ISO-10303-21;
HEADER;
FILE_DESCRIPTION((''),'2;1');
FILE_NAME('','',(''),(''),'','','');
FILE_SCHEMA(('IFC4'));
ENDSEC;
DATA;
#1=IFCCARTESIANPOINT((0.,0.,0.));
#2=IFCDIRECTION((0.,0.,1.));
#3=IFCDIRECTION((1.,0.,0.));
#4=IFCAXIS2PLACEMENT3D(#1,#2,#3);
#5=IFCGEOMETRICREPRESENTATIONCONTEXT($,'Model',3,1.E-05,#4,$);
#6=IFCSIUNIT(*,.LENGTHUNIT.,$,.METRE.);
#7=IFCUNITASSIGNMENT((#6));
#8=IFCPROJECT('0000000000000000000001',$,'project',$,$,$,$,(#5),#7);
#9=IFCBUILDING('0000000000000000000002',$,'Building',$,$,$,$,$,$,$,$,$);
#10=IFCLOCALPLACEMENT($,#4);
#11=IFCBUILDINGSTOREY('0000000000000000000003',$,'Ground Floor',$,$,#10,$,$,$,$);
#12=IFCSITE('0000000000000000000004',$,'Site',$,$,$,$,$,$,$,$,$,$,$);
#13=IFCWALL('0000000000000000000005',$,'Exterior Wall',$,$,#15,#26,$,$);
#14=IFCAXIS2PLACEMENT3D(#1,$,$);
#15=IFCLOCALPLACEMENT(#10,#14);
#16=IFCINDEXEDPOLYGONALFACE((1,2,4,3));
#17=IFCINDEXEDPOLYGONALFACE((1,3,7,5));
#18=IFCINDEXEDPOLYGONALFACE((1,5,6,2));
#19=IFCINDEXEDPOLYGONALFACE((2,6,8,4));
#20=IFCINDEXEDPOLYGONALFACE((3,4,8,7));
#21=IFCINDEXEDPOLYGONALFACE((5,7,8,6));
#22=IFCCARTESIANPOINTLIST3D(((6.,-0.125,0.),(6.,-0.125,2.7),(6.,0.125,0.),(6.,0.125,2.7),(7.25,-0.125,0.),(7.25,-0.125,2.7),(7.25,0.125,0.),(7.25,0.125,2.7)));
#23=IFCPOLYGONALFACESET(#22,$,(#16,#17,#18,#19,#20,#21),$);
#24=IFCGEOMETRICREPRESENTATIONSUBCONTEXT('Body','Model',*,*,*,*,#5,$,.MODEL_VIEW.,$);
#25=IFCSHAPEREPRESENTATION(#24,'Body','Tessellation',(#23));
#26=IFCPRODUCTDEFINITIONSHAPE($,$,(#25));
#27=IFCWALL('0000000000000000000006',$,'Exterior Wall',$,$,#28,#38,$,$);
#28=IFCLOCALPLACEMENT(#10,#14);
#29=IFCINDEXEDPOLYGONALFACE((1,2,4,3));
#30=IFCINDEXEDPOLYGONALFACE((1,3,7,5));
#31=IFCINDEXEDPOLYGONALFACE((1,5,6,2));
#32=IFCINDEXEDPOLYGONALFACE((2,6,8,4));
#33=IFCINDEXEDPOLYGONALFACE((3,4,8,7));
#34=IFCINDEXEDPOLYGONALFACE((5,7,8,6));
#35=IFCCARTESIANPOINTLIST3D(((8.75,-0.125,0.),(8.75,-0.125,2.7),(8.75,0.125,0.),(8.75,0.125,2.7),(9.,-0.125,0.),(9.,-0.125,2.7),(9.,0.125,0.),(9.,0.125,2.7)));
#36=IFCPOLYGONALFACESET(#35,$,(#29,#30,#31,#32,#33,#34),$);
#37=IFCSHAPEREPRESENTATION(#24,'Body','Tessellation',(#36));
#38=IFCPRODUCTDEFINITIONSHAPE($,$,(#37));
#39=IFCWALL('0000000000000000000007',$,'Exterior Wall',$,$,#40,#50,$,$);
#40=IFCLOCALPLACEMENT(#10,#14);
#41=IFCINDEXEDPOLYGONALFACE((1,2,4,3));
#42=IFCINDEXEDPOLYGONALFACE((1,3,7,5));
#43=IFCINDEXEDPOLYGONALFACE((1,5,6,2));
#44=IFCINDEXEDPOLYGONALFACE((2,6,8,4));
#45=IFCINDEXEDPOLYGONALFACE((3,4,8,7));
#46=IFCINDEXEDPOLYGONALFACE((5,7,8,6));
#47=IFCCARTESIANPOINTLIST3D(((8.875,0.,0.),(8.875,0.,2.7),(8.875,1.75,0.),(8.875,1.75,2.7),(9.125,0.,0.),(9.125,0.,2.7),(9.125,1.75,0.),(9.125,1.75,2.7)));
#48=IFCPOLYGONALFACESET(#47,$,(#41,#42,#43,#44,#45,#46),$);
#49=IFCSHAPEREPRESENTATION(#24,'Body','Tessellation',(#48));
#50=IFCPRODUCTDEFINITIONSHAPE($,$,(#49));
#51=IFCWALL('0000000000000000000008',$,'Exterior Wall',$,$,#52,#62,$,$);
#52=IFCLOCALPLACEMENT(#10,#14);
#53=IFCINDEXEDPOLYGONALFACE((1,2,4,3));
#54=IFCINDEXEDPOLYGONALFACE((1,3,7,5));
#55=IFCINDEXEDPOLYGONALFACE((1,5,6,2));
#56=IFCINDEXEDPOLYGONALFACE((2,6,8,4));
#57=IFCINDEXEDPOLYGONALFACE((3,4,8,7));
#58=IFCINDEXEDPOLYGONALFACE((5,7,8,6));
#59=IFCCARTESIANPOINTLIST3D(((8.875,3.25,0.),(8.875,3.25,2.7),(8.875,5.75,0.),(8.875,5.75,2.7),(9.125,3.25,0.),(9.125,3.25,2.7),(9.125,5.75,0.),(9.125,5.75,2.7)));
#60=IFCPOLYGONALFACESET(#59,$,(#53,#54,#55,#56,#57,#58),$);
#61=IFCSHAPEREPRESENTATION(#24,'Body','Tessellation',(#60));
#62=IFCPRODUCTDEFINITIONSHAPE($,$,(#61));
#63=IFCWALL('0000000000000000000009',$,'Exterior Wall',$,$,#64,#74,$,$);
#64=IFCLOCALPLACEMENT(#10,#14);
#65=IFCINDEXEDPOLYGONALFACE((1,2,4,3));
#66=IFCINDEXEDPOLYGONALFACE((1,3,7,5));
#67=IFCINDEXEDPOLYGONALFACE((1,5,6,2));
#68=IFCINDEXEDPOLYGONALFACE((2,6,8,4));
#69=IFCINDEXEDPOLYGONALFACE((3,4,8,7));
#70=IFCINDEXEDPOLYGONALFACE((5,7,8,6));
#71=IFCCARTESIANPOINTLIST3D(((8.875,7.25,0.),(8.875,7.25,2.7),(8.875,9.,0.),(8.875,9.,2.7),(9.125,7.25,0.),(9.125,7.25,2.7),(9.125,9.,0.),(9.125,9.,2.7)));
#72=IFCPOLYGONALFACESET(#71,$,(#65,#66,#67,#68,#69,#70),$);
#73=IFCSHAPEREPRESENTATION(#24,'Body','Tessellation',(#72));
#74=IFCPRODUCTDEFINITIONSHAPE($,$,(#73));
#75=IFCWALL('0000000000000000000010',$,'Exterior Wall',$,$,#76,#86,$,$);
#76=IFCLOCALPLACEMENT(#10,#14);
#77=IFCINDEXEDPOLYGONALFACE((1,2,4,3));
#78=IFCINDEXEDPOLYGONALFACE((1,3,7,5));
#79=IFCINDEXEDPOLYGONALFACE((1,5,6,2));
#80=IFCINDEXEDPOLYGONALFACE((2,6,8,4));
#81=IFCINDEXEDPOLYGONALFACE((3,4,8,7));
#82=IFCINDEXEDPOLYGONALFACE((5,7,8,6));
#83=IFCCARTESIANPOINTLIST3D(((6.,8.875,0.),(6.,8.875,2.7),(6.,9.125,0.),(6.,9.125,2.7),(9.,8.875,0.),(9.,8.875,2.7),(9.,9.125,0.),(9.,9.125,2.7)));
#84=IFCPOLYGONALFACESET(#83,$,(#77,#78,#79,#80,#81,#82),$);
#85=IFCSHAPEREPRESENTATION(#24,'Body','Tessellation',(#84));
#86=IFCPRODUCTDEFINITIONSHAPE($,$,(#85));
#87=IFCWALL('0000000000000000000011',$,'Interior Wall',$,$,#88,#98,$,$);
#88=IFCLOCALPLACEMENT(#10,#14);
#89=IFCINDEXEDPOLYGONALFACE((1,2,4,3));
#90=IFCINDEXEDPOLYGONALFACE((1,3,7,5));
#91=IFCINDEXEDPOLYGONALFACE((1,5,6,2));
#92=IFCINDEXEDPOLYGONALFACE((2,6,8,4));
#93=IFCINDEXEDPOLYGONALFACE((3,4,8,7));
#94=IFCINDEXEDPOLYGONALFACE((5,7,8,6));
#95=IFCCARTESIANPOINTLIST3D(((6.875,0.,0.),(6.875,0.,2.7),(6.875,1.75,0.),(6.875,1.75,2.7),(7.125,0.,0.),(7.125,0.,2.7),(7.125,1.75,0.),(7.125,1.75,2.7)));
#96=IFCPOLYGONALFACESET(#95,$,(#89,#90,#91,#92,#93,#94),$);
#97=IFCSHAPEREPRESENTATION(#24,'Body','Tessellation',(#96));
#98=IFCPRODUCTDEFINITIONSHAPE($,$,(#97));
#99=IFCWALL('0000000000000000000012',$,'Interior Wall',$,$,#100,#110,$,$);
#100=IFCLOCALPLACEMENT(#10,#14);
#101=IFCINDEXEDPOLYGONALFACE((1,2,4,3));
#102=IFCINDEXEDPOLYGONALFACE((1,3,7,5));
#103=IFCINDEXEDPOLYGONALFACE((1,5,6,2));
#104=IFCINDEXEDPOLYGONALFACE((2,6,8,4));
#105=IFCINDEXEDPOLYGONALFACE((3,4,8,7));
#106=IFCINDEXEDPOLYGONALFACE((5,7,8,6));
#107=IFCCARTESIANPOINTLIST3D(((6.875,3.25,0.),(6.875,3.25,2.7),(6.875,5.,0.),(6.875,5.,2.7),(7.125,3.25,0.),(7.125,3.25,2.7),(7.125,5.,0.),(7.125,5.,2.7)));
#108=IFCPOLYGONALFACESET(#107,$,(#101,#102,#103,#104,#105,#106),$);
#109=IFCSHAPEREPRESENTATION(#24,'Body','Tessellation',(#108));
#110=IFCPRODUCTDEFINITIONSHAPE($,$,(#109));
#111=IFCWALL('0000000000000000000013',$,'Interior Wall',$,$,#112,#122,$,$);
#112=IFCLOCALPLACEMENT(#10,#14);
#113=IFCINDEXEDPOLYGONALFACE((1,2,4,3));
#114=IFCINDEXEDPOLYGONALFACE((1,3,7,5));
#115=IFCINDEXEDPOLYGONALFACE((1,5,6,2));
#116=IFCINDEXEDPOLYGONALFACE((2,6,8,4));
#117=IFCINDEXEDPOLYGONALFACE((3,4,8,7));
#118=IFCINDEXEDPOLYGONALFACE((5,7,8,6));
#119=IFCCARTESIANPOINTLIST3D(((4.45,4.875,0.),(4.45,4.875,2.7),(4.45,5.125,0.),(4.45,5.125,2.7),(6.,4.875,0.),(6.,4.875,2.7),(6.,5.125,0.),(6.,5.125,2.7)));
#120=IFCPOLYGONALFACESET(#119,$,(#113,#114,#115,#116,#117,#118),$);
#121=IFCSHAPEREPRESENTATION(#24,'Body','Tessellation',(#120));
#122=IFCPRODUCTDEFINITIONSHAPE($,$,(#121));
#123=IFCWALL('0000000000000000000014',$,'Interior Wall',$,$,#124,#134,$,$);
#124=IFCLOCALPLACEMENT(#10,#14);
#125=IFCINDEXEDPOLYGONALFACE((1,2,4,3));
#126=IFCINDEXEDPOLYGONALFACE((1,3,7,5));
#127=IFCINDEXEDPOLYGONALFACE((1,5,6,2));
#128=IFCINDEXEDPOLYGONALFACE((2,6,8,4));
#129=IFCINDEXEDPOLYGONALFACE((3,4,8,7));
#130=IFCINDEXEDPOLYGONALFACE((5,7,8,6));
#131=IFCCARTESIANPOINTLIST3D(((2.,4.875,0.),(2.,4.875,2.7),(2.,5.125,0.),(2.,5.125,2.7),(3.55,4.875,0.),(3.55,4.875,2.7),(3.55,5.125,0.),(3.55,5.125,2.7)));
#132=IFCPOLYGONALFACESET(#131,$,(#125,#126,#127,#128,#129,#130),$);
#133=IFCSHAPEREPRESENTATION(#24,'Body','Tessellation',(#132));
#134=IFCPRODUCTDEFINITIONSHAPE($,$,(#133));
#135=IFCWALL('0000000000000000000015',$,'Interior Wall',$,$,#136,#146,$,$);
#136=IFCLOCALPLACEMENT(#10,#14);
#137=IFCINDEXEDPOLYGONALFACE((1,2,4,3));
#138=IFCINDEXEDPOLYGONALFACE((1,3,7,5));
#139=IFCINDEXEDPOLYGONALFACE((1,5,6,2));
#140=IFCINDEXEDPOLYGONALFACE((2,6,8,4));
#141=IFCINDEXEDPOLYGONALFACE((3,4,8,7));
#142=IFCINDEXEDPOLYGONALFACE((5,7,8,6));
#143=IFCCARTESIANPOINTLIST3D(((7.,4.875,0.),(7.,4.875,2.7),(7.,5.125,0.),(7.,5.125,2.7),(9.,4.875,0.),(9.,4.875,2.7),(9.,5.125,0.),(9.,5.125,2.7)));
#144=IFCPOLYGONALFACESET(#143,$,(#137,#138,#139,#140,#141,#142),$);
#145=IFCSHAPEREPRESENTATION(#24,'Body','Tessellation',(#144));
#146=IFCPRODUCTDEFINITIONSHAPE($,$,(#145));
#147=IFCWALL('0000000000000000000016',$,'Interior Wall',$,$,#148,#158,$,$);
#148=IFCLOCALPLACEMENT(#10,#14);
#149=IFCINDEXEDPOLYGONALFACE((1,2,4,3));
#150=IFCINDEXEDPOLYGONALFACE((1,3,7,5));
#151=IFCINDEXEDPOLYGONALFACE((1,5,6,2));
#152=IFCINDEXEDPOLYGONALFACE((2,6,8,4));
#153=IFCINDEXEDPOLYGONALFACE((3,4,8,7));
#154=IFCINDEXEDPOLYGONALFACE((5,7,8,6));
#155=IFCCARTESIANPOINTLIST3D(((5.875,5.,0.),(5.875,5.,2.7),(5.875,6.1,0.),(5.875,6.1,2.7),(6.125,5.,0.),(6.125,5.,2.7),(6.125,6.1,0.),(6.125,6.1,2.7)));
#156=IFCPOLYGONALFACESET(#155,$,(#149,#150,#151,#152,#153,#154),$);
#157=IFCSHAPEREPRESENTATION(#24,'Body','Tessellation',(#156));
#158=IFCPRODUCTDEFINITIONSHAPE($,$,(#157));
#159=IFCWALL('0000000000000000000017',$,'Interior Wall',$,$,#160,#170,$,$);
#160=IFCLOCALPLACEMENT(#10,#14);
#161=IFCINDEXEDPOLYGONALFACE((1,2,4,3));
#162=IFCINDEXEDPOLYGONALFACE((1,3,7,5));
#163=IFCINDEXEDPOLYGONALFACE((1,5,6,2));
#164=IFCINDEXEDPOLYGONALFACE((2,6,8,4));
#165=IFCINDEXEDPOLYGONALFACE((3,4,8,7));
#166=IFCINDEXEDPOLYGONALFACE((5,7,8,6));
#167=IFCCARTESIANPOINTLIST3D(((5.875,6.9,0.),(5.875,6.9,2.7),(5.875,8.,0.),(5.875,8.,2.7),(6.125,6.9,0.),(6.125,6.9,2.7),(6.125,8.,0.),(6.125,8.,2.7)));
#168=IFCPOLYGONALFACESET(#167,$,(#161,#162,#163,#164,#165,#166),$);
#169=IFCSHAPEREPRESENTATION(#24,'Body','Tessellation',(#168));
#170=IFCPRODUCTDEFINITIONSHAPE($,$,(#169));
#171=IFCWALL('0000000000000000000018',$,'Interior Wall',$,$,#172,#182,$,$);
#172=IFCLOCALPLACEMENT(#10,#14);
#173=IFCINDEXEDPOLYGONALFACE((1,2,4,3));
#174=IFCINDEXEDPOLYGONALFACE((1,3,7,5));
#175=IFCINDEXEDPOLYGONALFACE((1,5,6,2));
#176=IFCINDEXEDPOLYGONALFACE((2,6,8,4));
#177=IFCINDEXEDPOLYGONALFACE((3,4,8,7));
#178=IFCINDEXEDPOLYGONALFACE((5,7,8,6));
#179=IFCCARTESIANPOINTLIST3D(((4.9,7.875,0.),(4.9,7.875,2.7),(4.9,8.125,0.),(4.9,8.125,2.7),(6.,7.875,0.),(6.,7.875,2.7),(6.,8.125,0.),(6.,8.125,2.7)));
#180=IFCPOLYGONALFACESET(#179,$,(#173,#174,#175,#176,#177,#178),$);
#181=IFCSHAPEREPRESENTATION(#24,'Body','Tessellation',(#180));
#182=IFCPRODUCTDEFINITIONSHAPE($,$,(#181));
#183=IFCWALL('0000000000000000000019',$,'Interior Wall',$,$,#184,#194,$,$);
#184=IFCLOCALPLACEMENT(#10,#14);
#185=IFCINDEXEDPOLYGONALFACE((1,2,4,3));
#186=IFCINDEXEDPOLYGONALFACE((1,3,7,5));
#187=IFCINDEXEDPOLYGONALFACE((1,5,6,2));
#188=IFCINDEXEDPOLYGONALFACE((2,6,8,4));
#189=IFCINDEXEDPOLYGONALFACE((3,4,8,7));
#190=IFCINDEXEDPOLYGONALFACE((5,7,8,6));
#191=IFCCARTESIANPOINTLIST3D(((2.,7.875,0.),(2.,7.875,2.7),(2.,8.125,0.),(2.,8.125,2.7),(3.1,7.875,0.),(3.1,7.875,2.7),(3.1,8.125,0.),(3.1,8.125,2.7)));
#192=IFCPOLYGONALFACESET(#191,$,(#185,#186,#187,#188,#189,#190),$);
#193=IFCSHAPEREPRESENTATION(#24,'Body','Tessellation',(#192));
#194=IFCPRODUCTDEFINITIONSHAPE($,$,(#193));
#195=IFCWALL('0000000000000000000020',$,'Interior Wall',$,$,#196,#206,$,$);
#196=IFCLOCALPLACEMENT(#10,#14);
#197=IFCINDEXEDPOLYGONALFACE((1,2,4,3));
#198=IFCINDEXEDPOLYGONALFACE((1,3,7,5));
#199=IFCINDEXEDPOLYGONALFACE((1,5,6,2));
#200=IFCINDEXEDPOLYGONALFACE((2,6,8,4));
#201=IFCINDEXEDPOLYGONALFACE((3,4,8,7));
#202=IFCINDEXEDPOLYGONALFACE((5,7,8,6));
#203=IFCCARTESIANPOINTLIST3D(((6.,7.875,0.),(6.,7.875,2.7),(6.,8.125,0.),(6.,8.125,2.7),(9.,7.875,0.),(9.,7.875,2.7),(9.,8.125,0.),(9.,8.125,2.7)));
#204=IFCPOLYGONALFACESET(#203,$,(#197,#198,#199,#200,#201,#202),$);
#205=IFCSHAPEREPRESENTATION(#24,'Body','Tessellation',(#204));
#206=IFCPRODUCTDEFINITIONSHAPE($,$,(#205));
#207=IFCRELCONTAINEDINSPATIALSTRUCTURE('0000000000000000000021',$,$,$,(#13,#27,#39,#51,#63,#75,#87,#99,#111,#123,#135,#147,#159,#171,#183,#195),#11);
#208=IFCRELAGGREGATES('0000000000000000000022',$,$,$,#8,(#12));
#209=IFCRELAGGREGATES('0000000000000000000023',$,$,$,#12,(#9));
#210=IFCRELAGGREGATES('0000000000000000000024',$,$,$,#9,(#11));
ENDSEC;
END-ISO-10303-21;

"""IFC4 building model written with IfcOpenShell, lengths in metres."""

from ifc_helpers import new_model, si_unit, frame, origin_with_axes, place, context, subcontext, project, spatial, indexed_curve, outline, extrude, element, save


model = new_model("IFC4")

# Units and contexts
model_context = context("Model", 3, precision=1e-05, world=origin_with_axes())
body_context = subcontext(model_context, "Body", "Model", "MODEL_VIEW")
ifc_project = project(units=[si_unit("LENGTHUNIT", "METRE")], contexts=[model_context])

# Site, building, storey
site = spatial("IfcSite", under=ifc_project, Name="Site")
building = spatial("IfcBuilding", under=site, Name="Building")
storey_placement = place(None, origin_with_axes())
storey = spatial("IfcBuildingStorey", under=building, at=storey_placement, Name="Ground Floor")

# Walls
wall_1_placement = place(storey_placement, frame((6.0, 0.0, 0.0), z_axis=(0.0, 0.0, 1.0), x_axis=(1.0, 0.0, 0.0)))
element("IfcWall", 1, at=wall_1_placement, inside=storey, Name="Exterior Wall", context=body_context, shape_type="SweptSolid", body=[
    extrude(outline(indexed_curve([(0.0, 0.0), (0.0, 0.25), (1.25, 0.25), (1.25, 0.0), (0.0, 0.0)], self_intersect=False)), frame((0.0, -0.125, 0.0), z_axis=(0.0, 0.0, 1.0), x_axis=(1.0, 0.0, 0.0)), (0.0, 0.0, 1.0), 2.7),
])
wall_2_placement = place(storey_placement, frame((8.75, 0.0, 0.0), z_axis=(0.0, 0.0, 1.0), x_axis=(1.0, 0.0, 0.0)))
element("IfcWall", 2, at=wall_2_placement, inside=storey, Name="Exterior Wall", context=body_context, shape_type="SweptSolid", body=[
    extrude(outline(indexed_curve([(0.0, 0.0), (0.0, 0.25), (0.25, 0.25), (0.25, 0.0), (0.0, 0.0)], self_intersect=False)), frame((0.0, -0.125, 0.0), z_axis=(0.0, 0.0, 1.0), x_axis=(1.0, 0.0, 0.0)), (0.0, 0.0, 1.0), 2.7),
])
wall_3_placement = place(storey_placement, frame((9.0, 0.0, 0.0), z_axis=(0.0, 0.0, 1.0), x_axis=(0.0, 1.0, 0.0)))
element("IfcWall", 3, at=wall_3_placement, inside=storey, Name="Exterior Wall", context=body_context, shape_type="SweptSolid", body=[
    extrude(outline(indexed_curve([(0.0, 0.0), (0.0, 0.25), (1.75, 0.25), (1.75, 0.0), (0.0, 0.0)], self_intersect=False)), frame((0.0, -0.125, 0.0), z_axis=(0.0, 0.0, 1.0), x_axis=(1.0, 0.0, 0.0)), (0.0, 0.0, 1.0), 2.7),
])
wall_4_placement = place(storey_placement, frame((9.0, 3.25, 0.0), z_axis=(0.0, 0.0, 1.0), x_axis=(0.0, 1.0, 0.0)))
element("IfcWall", 4, at=wall_4_placement, inside=storey, Name="Exterior Wall", context=body_context, shape_type="SweptSolid", body=[
    extrude(outline(indexed_curve([(0.0, 0.0), (0.0, 0.25), (2.5, 0.25), (2.5, 0.0), (0.0, 0.0)], self_intersect=False)), frame((0.0, -0.125, 0.0), z_axis=(0.0, 0.0, 1.0), x_axis=(1.0, 0.0, 0.0)), (0.0, 0.0, 1.0), 2.7),
])
wall_5_placement = place(storey_placement, frame((9.0, 7.25, 0.0), z_axis=(0.0, 0.0, 1.0), x_axis=(0.0, 1.0, 0.0)))
element("IfcWall", 5, at=wall_5_placement, inside=storey, Name="Exterior Wall", context=body_context, shape_type="SweptSolid", body=[
    extrude(outline(indexed_curve([(0.0, 0.0), (0.0, 0.25), (1.75, 0.25), (1.75, 0.0), (0.0, 0.0)], self_intersect=False)), frame((0.0, -0.125, 0.0), z_axis=(0.0, 0.0, 1.0), x_axis=(1.0, 0.0, 0.0)), (0.0, 0.0, 1.0), 2.7),
])
wall_6_placement = place(storey_placement, frame((9.0, 9.0, 0.0), z_axis=(0.0, 0.0, 1.0), x_axis=(-1.0, 0.0, 0.0)))
element("IfcWall", 6, at=wall_6_placement, inside=storey, Name="Exterior Wall", context=body_context, shape_type="SweptSolid", body=[
    extrude(outline(indexed_curve([(0.0, 0.0), (0.0, 0.25), (3.0, 0.25), (3.0, 0.0), (0.0, 0.0)], self_intersect=False)), frame((0.0, -0.125, 0.0), z_axis=(0.0, 0.0, 1.0), x_axis=(1.0, 0.0, 0.0)), (0.0, 0.0, 1.0), 2.7),
])
for number, where, z_axis, x_axis, name in (
    (7, (7.0, 0.0, 0.0), (0.0, 0.0, 1.0), (0.0, 1.0, 0.0), "Interior Wall"),
    (8, (7.0, 3.25, 0.0), (0.0, 0.0, 1.0), (0.0, 1.0, 0.0), "Interior Wall"),
):
    element("IfcWall", number, at=place(storey_placement, frame(where, z_axis=z_axis, x_axis=x_axis)), inside=storey, Name=name, context=body_context, shape_type="SweptSolid", body=[
        extrude(outline(indexed_curve([(0.0, 0.0), (0.0, 0.25), (1.75, 0.25), (1.75, 0.0), (0.0, 0.0)], self_intersect=False)), frame((0.0, -0.125, 0.0), z_axis=(0.0, 0.0, 1.0), x_axis=(1.0, 0.0, 0.0)), (0.0, 0.0, 1.0), 2.7),
    ])
for number, where, z_axis, x_axis, name in (
    (9, (6.0, 5.0, 0.0), (0.0, 0.0, 1.0), (-1.0, 0.0, 0.0), "Interior Wall"),
    (10, (3.55, 5.0, 0.0), (0.0, 0.0, 1.0), (-1.0, 0.0, 0.0), "Interior Wall"),
):
    element("IfcWall", number, at=place(storey_placement, frame(where, z_axis=z_axis, x_axis=x_axis)), inside=storey, Name=name, context=body_context, shape_type="SweptSolid", body=[
        extrude(outline(indexed_curve([(0.0, 0.0), (0.0, 0.25), (1.55, 0.25), (1.55, 0.0), (0.0, 0.0)], self_intersect=False)), frame((0.0, -0.125, 0.0), z_axis=(0.0, 0.0, 1.0), x_axis=(1.0, 0.0, 0.0)), (0.0, 0.0, 1.0), 2.7),
    ])
wall_7_placement = place(storey_placement, frame((9.0, 5.0, 0.0), z_axis=(0.0, 0.0, 1.0), x_axis=(-1.0, 0.0, 0.0)))
element("IfcWall", 11, at=wall_7_placement, inside=storey, Name="Interior Wall", context=body_context, shape_type="SweptSolid", body=[
    extrude(outline(indexed_curve([(0.0, 0.0), (0.0, 0.25), (2.0, 0.25), (2.0, 0.0), (0.0, 0.0)], self_intersect=False)), frame((0.0, -0.125, 0.0), z_axis=(0.0, 0.0, 1.0), x_axis=(1.0, 0.0, 0.0)), (0.0, 0.0, 1.0), 2.7),
])
for number, where, z_axis, x_axis, name in (
    (12, (6.0, 5.0, 0.0), (0.0, 0.0, 1.0), (0.0, 1.0, 0.0), "Interior Wall"),
    (13, (6.0, 6.9, 0.0), (0.0, 0.0, 1.0), (0.0, 1.0, 0.0), "Interior Wall"),
    (14, (6.0, 8.0, 0.0), (0.0, 0.0, 1.0), (-1.0, 0.0, 0.0), "Interior Wall"),
):
    element("IfcWall", number, at=place(storey_placement, frame(where, z_axis=z_axis, x_axis=x_axis)), inside=storey, Name=name, context=body_context, shape_type="SweptSolid", body=[
        extrude(outline(indexed_curve([(0.0, 0.0), (0.0, 0.25), (1.1, 0.25), (1.1, 0.0), (0.0, 0.0)], self_intersect=False)), frame((0.0, -0.125, 0.0), z_axis=(0.0, 0.0, 1.0), x_axis=(1.0, 0.0, 0.0)), (0.0, 0.0, 1.0), 2.7),
    ])
wall_8_placement = place(storey_placement, frame((3.1, 8.0, 0.0), z_axis=(0.0, 0.0, 1.0), x_axis=(-1.0, 0.0, 0.0)))
element("IfcWall", 15, at=wall_8_placement, inside=storey, Name="Interior Wall", context=body_context, shape_type="SweptSolid", body=[
    extrude(outline(indexed_curve([(0.0, 0.0), (0.0, 0.25), (1.1, 0.25), (1.1, 0.0), (0.0, 0.0)], self_intersect=False)), frame((0.0, -0.125, 0.0), z_axis=(0.0, 0.0, 1.0), x_axis=(1.0, 0.0, 0.0)), (0.0, 0.0, 1.0), 2.7),
])
wall_9_placement = place(storey_placement, frame((9.0, 8.0, 0.0), z_axis=(0.0, 0.0, 1.0), x_axis=(-1.0, 0.0, 0.0)))
element("IfcWall", 16, at=wall_9_placement, inside=storey, Name="Interior Wall", context=body_context, shape_type="SweptSolid", body=[
    extrude(outline(indexed_curve([(0.0, 0.0), (0.0, 0.25), (3.0, 0.25), (3.0, 0.0), (0.0, 0.0)], self_intersect=False)), frame((0.0, -0.125, 0.0), z_axis=(0.0, 0.0, 1.0), x_axis=(1.0, 0.0, 0.0)), (0.0, 0.0, 1.0), 2.7),
])

save(model, "model.ifc")
